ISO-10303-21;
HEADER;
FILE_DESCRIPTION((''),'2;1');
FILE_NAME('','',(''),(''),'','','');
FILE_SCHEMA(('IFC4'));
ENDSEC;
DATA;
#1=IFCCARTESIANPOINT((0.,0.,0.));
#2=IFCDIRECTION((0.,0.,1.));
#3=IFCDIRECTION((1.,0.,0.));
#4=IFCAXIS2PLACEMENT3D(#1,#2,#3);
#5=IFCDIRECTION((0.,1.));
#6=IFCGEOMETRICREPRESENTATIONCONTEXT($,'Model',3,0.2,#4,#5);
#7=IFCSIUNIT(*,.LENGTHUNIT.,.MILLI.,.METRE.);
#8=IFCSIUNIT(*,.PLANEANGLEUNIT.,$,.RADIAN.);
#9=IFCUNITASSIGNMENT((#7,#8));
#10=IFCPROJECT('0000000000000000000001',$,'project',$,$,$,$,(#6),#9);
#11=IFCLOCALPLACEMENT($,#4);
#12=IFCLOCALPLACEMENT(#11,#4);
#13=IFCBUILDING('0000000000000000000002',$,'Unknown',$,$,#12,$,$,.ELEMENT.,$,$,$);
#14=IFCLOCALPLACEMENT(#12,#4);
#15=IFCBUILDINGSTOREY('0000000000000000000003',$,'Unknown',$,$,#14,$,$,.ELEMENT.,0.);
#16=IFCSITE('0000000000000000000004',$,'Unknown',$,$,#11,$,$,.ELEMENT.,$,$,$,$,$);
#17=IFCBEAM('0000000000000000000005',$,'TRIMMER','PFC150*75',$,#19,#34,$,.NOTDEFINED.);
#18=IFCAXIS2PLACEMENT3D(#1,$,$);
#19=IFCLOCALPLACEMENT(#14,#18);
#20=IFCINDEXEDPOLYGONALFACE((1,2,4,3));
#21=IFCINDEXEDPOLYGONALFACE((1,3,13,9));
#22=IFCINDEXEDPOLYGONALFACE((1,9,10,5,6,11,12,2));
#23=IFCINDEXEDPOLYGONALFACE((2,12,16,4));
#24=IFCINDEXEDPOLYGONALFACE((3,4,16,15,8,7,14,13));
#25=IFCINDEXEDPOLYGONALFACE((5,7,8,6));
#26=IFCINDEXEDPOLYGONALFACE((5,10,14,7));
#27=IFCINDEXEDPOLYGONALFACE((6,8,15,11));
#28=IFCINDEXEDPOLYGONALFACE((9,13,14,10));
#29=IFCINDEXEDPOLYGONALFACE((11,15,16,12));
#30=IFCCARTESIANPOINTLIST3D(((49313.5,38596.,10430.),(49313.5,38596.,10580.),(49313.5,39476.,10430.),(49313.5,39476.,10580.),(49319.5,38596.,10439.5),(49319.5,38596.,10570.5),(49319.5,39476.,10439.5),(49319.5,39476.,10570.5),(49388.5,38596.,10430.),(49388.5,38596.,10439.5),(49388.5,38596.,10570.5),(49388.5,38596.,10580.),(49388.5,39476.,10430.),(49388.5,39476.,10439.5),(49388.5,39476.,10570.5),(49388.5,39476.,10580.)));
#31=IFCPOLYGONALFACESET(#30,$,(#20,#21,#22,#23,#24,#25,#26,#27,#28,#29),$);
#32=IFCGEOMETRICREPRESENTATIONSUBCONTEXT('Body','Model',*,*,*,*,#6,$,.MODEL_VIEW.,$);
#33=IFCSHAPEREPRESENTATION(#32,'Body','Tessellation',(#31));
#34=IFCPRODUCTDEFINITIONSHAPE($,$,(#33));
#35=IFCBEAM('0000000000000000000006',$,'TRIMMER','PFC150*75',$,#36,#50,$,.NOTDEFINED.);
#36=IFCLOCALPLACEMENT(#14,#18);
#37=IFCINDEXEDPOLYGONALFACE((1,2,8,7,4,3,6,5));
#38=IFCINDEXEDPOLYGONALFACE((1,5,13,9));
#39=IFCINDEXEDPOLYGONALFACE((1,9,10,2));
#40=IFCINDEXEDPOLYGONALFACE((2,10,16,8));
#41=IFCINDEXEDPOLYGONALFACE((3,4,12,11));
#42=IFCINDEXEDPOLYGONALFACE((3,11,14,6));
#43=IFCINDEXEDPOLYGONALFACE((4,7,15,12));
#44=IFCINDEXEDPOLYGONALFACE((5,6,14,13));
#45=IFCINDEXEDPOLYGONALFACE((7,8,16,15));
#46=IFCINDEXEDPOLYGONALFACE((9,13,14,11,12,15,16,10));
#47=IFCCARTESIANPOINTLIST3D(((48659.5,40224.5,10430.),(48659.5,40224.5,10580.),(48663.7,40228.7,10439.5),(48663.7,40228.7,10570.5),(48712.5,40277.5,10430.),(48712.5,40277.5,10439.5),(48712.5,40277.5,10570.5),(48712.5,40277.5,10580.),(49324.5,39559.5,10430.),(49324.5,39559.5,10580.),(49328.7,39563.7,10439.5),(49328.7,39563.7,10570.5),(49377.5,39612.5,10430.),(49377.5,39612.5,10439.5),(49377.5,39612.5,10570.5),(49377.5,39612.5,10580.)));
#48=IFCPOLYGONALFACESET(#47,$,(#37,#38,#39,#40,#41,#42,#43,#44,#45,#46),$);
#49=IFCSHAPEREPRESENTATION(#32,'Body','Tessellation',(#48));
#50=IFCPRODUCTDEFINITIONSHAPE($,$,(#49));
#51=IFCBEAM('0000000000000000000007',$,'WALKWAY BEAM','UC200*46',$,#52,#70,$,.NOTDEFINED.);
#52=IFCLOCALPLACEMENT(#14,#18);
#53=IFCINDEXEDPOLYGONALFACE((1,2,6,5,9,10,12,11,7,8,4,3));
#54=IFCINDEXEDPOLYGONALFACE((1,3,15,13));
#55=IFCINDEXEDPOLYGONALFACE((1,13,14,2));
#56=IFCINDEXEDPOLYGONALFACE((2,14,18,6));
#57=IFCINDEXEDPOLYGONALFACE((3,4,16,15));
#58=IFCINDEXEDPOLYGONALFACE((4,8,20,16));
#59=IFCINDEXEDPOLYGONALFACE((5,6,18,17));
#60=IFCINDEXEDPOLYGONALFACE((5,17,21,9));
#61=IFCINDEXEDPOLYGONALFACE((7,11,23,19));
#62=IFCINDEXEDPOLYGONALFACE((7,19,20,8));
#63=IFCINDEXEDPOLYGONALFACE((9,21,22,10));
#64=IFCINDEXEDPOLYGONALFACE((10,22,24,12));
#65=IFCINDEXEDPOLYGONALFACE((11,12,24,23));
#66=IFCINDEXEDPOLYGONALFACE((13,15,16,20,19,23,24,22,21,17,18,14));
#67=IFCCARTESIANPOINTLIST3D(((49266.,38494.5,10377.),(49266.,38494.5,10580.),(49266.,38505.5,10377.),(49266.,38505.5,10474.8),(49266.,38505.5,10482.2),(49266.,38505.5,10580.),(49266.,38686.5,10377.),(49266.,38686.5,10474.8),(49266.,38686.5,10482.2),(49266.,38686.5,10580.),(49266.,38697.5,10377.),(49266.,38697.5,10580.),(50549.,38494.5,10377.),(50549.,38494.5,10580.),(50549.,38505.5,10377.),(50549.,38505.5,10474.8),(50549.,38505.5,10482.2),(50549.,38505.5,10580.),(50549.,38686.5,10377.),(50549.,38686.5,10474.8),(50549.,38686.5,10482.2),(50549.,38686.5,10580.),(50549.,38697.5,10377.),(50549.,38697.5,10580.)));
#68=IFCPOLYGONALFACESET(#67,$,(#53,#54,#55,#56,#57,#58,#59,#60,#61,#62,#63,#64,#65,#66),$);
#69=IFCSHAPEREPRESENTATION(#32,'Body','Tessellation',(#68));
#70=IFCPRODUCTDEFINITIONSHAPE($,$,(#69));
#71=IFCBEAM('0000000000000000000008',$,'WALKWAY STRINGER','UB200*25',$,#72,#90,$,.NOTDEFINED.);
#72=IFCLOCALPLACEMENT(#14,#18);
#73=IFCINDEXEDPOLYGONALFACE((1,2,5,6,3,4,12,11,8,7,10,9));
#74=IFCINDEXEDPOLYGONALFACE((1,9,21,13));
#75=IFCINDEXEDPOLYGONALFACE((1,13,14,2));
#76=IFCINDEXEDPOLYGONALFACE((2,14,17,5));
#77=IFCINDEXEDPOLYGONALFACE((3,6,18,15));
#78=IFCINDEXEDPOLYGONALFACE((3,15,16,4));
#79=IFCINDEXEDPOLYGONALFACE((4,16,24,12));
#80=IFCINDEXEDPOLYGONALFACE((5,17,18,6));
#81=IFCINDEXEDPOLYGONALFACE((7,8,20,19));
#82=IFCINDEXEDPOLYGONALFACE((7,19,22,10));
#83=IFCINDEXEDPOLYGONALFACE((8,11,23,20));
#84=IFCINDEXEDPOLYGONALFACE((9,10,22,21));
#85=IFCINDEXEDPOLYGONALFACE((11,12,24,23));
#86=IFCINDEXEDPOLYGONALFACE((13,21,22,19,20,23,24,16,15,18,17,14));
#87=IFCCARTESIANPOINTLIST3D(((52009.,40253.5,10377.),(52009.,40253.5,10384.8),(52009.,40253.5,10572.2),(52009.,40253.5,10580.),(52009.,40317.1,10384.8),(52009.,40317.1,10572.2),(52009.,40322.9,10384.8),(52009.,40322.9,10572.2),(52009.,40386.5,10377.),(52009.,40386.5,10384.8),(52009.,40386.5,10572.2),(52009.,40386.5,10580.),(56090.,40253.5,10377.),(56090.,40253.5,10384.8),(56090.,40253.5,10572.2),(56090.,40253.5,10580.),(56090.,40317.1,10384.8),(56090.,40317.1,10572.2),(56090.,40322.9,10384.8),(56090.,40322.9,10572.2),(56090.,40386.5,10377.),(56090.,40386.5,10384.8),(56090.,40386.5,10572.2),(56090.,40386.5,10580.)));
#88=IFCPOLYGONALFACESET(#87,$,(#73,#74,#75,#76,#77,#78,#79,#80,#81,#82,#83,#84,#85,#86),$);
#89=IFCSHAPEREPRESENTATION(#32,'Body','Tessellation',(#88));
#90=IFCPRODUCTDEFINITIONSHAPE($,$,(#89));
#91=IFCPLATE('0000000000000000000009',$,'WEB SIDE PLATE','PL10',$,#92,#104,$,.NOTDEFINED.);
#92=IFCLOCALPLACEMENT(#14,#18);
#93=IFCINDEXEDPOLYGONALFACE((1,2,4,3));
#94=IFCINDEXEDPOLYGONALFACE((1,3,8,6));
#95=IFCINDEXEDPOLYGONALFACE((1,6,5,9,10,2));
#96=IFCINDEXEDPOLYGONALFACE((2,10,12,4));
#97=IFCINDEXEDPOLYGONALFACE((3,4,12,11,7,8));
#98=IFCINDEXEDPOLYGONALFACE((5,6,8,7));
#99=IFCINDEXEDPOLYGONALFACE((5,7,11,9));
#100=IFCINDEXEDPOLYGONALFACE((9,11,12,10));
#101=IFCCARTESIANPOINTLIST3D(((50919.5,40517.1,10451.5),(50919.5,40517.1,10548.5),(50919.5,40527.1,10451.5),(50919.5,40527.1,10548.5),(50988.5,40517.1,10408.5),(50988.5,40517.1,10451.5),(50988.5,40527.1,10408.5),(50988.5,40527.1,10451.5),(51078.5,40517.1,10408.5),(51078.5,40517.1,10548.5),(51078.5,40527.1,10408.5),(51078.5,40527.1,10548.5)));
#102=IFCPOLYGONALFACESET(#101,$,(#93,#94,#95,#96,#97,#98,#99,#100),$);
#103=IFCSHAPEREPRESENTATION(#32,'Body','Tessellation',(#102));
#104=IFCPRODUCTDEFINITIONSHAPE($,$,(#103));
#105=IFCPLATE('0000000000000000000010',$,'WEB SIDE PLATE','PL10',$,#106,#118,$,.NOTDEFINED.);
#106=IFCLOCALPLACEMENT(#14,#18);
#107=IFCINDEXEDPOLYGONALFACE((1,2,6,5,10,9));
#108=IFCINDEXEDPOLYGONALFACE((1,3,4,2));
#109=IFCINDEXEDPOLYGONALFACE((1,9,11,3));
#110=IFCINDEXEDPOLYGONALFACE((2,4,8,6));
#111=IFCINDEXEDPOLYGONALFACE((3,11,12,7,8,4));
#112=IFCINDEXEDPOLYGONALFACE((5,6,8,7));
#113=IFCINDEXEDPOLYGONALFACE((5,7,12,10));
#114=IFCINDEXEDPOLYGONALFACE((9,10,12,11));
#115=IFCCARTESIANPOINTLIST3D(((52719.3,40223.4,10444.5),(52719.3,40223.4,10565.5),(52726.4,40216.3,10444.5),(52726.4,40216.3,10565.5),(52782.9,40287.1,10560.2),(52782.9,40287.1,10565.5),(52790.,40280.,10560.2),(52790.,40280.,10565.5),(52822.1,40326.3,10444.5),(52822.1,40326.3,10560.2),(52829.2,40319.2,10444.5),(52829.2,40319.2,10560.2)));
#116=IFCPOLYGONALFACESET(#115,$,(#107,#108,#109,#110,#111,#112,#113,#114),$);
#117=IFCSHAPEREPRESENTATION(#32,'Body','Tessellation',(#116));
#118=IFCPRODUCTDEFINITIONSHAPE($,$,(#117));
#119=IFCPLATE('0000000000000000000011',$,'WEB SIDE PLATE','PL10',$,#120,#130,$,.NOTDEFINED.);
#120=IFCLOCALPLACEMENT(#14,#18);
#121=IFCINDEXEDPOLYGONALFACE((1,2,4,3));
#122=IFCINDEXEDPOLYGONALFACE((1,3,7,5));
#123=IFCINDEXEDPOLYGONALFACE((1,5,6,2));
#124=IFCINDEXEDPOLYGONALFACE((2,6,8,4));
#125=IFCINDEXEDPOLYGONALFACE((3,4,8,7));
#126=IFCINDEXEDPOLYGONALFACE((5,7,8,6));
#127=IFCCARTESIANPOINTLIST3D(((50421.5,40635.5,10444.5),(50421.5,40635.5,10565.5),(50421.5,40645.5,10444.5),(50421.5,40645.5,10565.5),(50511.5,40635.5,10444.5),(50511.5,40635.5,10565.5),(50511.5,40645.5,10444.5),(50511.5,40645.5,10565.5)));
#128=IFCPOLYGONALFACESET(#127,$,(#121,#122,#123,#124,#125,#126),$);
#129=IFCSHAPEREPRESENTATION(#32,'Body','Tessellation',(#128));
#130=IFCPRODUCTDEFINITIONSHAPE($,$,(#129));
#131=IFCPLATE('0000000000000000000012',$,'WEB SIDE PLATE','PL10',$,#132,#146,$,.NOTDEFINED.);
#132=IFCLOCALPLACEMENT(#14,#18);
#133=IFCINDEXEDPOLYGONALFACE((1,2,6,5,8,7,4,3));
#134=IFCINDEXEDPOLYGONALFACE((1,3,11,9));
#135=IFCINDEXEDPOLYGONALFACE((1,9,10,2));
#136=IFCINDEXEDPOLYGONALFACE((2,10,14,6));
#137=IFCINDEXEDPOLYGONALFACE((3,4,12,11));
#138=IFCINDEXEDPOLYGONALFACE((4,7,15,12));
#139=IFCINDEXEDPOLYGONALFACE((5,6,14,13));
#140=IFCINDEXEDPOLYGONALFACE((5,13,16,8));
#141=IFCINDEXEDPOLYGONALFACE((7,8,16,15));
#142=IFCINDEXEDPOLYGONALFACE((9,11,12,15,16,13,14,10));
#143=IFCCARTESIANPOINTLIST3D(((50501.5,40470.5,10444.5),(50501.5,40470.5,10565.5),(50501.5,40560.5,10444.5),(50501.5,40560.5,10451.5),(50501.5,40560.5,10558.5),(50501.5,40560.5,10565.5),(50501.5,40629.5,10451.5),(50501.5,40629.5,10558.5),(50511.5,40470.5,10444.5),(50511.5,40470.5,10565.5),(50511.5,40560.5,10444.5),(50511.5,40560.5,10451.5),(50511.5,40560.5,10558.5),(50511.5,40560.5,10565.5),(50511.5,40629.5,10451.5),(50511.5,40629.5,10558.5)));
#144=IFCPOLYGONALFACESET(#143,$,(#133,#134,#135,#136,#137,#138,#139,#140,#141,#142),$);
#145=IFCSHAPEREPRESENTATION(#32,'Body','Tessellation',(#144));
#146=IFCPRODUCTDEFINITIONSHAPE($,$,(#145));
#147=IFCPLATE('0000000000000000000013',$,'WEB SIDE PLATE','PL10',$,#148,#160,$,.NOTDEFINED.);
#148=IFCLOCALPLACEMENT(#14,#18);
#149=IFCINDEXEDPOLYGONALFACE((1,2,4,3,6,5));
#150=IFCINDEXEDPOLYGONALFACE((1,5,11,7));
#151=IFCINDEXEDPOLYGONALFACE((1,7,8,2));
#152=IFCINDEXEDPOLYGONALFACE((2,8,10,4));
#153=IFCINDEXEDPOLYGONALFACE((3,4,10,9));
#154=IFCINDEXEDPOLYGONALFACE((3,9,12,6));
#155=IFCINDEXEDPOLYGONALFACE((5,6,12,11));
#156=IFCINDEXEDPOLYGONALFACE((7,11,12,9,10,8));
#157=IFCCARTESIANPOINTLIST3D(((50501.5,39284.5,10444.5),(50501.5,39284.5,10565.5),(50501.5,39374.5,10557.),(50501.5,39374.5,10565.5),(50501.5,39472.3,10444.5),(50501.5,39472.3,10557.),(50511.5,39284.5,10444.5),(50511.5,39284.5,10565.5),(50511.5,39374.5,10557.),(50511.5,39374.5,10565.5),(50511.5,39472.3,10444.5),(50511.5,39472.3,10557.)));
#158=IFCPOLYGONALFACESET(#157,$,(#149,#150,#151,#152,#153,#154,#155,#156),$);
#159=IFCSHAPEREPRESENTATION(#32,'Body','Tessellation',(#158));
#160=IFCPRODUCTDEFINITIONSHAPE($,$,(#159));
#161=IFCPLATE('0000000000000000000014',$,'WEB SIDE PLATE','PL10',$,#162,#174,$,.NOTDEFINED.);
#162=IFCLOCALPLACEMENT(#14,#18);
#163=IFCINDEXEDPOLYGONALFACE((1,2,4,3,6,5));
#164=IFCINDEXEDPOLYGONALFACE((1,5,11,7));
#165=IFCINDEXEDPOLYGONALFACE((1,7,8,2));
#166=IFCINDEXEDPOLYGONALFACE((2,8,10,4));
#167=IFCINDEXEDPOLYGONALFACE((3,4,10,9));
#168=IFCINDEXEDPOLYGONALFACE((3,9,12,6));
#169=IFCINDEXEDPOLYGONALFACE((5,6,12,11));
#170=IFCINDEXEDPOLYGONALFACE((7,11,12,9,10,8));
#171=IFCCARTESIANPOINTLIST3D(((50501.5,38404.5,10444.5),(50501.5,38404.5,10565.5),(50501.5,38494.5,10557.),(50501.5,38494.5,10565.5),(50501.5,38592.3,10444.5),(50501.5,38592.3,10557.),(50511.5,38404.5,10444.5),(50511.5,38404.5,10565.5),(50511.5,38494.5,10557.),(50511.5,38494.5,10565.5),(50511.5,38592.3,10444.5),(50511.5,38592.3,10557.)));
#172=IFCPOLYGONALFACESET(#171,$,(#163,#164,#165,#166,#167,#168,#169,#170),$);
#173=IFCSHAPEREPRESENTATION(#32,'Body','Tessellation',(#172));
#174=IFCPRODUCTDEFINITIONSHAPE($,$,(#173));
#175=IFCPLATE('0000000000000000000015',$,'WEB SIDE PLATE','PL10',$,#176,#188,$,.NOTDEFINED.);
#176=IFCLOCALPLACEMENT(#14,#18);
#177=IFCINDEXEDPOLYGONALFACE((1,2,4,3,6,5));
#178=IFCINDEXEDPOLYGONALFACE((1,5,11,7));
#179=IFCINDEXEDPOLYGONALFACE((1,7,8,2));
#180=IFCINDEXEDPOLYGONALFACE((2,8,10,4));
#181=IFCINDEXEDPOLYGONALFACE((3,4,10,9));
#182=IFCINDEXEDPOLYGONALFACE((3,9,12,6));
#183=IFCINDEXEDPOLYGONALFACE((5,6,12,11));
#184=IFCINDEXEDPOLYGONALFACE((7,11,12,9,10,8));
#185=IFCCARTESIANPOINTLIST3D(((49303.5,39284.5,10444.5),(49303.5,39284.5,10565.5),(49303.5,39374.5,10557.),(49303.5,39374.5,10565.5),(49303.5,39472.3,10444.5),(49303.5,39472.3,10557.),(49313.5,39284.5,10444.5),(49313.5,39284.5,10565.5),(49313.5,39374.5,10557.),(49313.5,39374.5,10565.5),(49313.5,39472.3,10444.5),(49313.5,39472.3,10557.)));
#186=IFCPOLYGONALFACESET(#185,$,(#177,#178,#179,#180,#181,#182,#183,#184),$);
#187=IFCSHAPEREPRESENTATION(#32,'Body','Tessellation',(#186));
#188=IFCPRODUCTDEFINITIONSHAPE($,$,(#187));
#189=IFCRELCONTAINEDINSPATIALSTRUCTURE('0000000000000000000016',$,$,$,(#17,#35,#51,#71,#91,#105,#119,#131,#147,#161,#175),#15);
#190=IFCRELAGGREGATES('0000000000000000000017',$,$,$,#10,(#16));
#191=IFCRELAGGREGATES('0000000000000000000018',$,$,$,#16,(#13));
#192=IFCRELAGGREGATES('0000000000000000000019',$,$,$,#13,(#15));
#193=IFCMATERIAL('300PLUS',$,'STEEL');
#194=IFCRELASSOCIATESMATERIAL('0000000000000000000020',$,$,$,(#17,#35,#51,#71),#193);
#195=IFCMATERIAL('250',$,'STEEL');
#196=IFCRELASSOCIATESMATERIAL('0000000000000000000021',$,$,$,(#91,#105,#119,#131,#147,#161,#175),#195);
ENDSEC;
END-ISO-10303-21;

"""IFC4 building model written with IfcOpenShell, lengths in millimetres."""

from ifc_helpers import new_model, si_unit, direction, frame, origin_with_axes, place, context, subcontext, project, spatial, line, indexed_curve, outline, extrude, material, element, save


model = new_model("IFC4")

# Units and contexts
model_context = context("Model", 3, precision=0.2, world=origin_with_axes(), true_north=direction((0.0, 1.0)))
body_context = subcontext(model_context, "Body", "Model", "MODEL_VIEW")
ifc_project = project(units=[si_unit("LENGTHUNIT", "METRE", prefix="MILLI"), si_unit("PLANEANGLEUNIT", "RADIAN")], contexts=[model_context])

# Site, building, storey
site_placement = place(None, origin_with_axes())
site = spatial("IfcSite", under=ifc_project, at=site_placement, Name="Unknown", CompositionType="ELEMENT")
building_placement = place(site_placement, origin_with_axes())
building = spatial("IfcBuilding", under=site, at=building_placement, Name="Unknown", CompositionType="ELEMENT")
storey_placement = place(building_placement, origin_with_axes())
storey = spatial("IfcBuildingStorey", under=building, at=storey_placement, Name="Unknown", CompositionType="ELEMENT", Elevation=0.0)

# Beams
ifc_material_1 = material(Name="300PLUS", Category="STEEL")
for number, where, z_axis, x_axis, name in (
    (1, (49351.0, 38596.0, 10505.0), (1.0, 0.0, 0.0), (0.0, 1.0, 0.0), "TRIMMER"),
):
    element("IfcBeam", number, at=place(storey_placement, frame(where, z_axis=z_axis, x_axis=x_axis)), inside=storey, material=ifc_material_1, Name=name, Description="PFC150*75", PredefinedType="NOTDEFINED", context=body_context, shape_type="SolidModel", body=[
        extrude(outline(indexed_curve([(-37.5, -75.0), (37.5, -75.0), (37.5, -65.5), (-31.5, -65.5), (-31.5, 65.5), (37.5, 65.5), (37.5, 75.0), (-37.5, 75.0)], segments=[line(1, 2, 3, 4, 5, 6, 7, 8, 1)])), frame((0.0, 0.0, 0.0), z_axis=(-1.0, 0.0, 0.0), x_axis=(0.0, 0.0, 1.0)), (0.0, 0.0, -1.0), 880.0),
    ])
beam_1_placement = place(storey_placement, frame((49351.0, 39586.0, 10505.0), z_axis=(0.707107, 0.707107, 0.0), x_axis=(-0.707107, 0.707107, 0.0)))
element("IfcBeam", 2, at=beam_1_placement, inside=storey, material=ifc_material_1, Name="TRIMMER", Description="PFC150*75", PredefinedType="NOTDEFINED", context=body_context, shape_type="SolidModel", body=[
    extrude(outline(indexed_curve([(-37.5, -75.0), (37.5, -75.0), (37.5, -65.5), (-31.5, -65.5), (-31.5, 65.5), (37.5, 65.5), (37.5, 75.0), (-37.5, 75.0)], segments=[line(1, 2, 3, 4, 5, 6, 7, 8, 1)])), frame((0.0, 0.0, 0.0), z_axis=(-1.0, 0.0, 0.0), x_axis=(0.0, 0.0, 1.0)), (0.0, 0.0, -1.0), 940.5),
])
beam_2_placement = place(storey_placement, frame((49266.0, 38596.0, 10478.5), z_axis=(0.0, 0.0, 1.0), x_axis=(1.0, 0.0, 0.0)))
element("IfcBeam", 3, at=beam_2_placement, inside=storey, material=ifc_material_1, Name="WALKWAY BEAM", Description="UC200*46", PredefinedType="NOTDEFINED", context=body_context, shape_type="SolidModel", body=[
    extrude(outline(indexed_curve([(-101.5, -101.5), (101.5, -101.5), (101.5, -90.5), (3.6, -90.5), (3.6, 90.5), (101.5, 90.5), (101.5, 101.5), (-101.5, 101.5), (-101.5, 90.5), (-3.6, 90.5), (-3.6, -90.5), (-101.5, -90.5)], segments=[line(1, 2, 3, 4, 5, 6, 7, 8, 9, 10, 11, 12, 1)])), frame((0.0, 0.0, 0.0), z_axis=(-1.0, 0.0, 0.0), x_axis=(0.0, 0.0, 1.0)), (0.0, 0.0, -1.0), 1283.0),
])
beam_3_placement = place(storey_placement, frame((52009.0, 40320.0, 10478.5), z_axis=(0.0, -1.0, 0.0), x_axis=(1.0, 0.0, 0.0)))
element("IfcBeam", 4, at=beam_3_placement, inside=storey, material=ifc_material_1, Name="WALKWAY STRINGER", Description="UB200*25", PredefinedType="NOTDEFINED", context=body_context, shape_type="SolidModel", body=[
    extrude(outline(indexed_curve([(-66.5, -101.5), (66.5, -101.5), (66.5, -93.7), (2.9, -93.7), (2.9, 93.7), (66.5, 93.7), (66.5, 101.5), (-66.5, 101.5), (-66.5, 93.7), (-2.9, 93.7), (-2.9, -93.7), (-66.5, -93.7)], segments=[line(1, 2, 3, 4, 5, 6, 7, 8, 9, 10, 11, 12, 1)])), frame((0.0, 0.0, 0.0), z_axis=(-1.0, 0.0, 0.0), x_axis=(0.0, 0.0, 1.0)), (0.0, 0.0, -1.0), 4081.0),
])

# Plates
ifc_material_2 = material(Name="250", Category="STEEL")
plate_1_placement = place(storey_placement, frame((51078.5, 40522.1, 10408.5), z_axis=(0.0, -1.0, 0.0), x_axis=(0.0, 0.0, 1.0)))
element("IfcPlate", 5, at=plate_1_placement, inside=storey, material=ifc_material_2, Name="WEB SIDE PLATE", Description="PL10", PredefinedType="NOTDEFINED", context=body_context, shape_type="SolidModel", body=[
    extrude(outline(indexed_curve([(0.0, 0.0), (140.0, 0.0), (140.0, 159.0), (43.0, 159.0), (43.0, 90.0), (0.0, 90.0)], segments=[line(1, 2, 3, 4, 5, 6, 1)])), frame((0.0, 0.0, 5.0), z_axis=(0.0, 0.0, 1.0), x_axis=(1.0, 0.0, 0.0)), (0.0, 0.0, -1.0), 10.0),
])
plate_2_placement = place(storey_placement, frame((52786.5, 40283.5, 10560.2), z_axis=(-0.707107, 0.707107, 0.0), x_axis=(0.707107, 0.707107, 0.0)))
element("IfcPlate", 6, at=plate_2_placement, inside=storey, material=ifc_material_2, Name="WEB SIDE PLATE", Description="PL10", PredefinedType="NOTDEFINED", context=body_context, shape_type="SolidModel", body=[
    extrude(outline(indexed_curve([(0.0, 0.0), (55.4, 0.0), (55.4, 115.7), (-90.0, 115.7), (-90.0, -5.3), (0.0, -5.3)], segments=[line(1, 2, 3, 4, 5, 6, 1)])), frame((0.0, 0.0, 5.0), z_axis=(0.0, 0.0, 1.0), x_axis=(1.0, 0.0, 0.0)), (0.0, 0.0, -1.0), 10.0),
])
plate_3_placement = place(storey_placement, frame((50511.5, 40640.5, 10444.5), z_axis=(0.0, 1.0, 0.0), x_axis=(-1.0, 0.0, 0.0)))
element("IfcPlate", 7, at=plate_3_placement, inside=storey, material=ifc_material_2, Name="WEB SIDE PLATE", Description="PL10", PredefinedType="NOTDEFINED", context=body_context, shape_type="SolidModel", body=[
    extrude(outline(indexed_curve([(0.0, 0.0), (90.0, 0.0), (90.0, 121.0), (0.0, 121.0)], segments=[line(1, 2, 3, 4, 1)])), frame((0.0, 0.0, 5.0), z_axis=(0.0, 0.0, 1.0), x_axis=(1.0, 0.0, 0.0)), (0.0, 0.0, -1.0), 10.0),
])
plate_4_placement = place(storey_placement, frame((50506.5, 40560.5, 10558.5), z_axis=(-1.0, 0.0, 0.0), x_axis=(0.0, 1.0, 0.0)))
element("IfcPlate", 8, at=plate_4_placement, inside=storey, material=ifc_material_2, Name="WEB SIDE PLATE", Description="PL10", PredefinedType="NOTDEFINED", context=body_context, shape_type="SolidModel", body=[
    extrude(outline(indexed_curve([(0.0, 0.0), (69.0, 0.0), (69.0, 107.0), (0.0, 107.0), (0.0, 114.0), (-90.0, 114.0), (-90.0, -7.0), (0.0, -7.0)], segments=[line(1, 2, 3, 4, 5, 6, 7, 8, 1)])), frame((0.0, 0.0, 5.0), z_axis=(0.0, 0.0, 1.0), x_axis=(1.0, 0.0, 0.0)), (0.0, 0.0, -1.0), 10.0),
])
for number, where, z_axis, x_axis, name in (
    (9, (50506.5, 39374.5, 10557.0), (-1.0, 0.0, 0.0), (0.0, 1.0, 0.0), "WEB SIDE PLATE"),
    (10, (50506.5, 38494.5, 10557.0), (-1.0, 0.0, 0.0), (0.0, 1.0, 0.0), "WEB SIDE PLATE"),
    (11, (49308.5, 39374.5, 10557.0), (-1.0, 0.0, 0.0), (0.0, 1.0, 0.0), "WEB SIDE PLATE"),
):
    element("IfcPlate", number, at=place(storey_placement, frame(where, z_axis=z_axis, x_axis=x_axis)), inside=storey, material=ifc_material_2, Name=name, Description="PL10", PredefinedType="NOTDEFINED", context=body_context, shape_type="SolidModel", body=[
        extrude(outline(indexed_curve([(0.0, 0.0), (97.8, 0.0), (97.8, 112.5), (-90.0, 112.5), (-90.0, -8.5), (0.0, -8.5)], segments=[line(1, 2, 3, 4, 5, 6, 1)])), frame((0.0, 0.0, 5.0), z_axis=(0.0, 0.0, 1.0), x_axis=(1.0, 0.0, 0.0)), (0.0, 0.0, -1.0), 10.0),
    ])

save(model, "model.ifc")
